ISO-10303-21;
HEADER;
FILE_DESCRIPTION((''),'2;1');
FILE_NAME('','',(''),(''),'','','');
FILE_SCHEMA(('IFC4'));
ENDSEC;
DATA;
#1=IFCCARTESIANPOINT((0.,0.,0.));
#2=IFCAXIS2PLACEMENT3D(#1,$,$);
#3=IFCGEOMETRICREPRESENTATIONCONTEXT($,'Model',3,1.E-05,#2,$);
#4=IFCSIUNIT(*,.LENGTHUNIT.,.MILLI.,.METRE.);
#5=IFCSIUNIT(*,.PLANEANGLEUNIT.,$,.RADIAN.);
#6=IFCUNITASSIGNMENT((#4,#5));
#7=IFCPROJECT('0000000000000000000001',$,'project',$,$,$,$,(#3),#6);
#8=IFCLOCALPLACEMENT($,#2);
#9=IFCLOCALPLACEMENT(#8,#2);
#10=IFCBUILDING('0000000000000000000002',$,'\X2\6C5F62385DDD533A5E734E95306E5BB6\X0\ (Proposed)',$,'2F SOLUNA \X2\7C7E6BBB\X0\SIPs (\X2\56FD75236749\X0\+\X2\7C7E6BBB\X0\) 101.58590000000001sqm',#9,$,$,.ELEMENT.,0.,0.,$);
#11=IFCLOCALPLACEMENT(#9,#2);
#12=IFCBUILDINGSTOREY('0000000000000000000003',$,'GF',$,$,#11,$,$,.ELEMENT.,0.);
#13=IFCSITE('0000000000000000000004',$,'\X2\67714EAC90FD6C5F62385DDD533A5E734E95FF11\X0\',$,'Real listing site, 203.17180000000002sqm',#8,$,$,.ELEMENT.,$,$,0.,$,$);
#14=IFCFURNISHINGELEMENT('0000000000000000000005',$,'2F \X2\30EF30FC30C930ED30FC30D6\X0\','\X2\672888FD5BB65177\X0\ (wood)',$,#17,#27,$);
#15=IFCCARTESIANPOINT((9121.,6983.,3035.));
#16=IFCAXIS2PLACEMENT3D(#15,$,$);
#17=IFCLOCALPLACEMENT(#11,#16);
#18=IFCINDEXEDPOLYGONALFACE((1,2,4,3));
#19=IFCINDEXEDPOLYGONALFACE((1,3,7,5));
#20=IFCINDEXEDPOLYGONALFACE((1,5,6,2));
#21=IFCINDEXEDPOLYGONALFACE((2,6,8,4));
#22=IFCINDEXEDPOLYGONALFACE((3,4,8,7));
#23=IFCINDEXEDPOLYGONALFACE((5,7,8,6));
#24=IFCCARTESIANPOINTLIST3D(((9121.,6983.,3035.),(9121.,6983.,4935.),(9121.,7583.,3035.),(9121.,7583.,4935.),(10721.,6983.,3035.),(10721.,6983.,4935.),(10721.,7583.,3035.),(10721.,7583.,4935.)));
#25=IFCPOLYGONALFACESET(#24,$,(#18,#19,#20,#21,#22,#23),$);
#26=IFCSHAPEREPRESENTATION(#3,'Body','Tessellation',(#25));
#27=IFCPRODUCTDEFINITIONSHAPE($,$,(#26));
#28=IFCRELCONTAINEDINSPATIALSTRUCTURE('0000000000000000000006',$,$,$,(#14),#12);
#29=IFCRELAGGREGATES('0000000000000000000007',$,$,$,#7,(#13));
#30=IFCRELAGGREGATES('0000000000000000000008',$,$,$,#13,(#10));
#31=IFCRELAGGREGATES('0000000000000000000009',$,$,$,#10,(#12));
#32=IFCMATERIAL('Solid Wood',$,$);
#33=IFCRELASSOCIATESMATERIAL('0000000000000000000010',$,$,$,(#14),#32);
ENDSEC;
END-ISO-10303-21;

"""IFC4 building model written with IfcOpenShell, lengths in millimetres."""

from ifc_helpers import new_model, si_unit, frame, frame_2d, origin, place, context, project, spatial, rectangle, extrude, material, element, save


model = new_model("IFC4")

# Units and contexts
model_context = context("Model", 3, precision=1e-05, world=origin())
ifc_project = project(units=[si_unit("LENGTHUNIT", "METRE", prefix="MILLI"), si_unit("PLANEANGLEUNIT", "RADIAN")], contexts=[model_context])

# Site, building, storey
site_placement = place(None, origin())
site = spatial("IfcSite", under=ifc_project, at=site_placement, Name="東京都江戸川区平井１", ObjectType="Real listing site, 203.17180000000002sqm", CompositionType="ELEMENT", RefElevation=0.0)
building_placement = place(site_placement, origin())
building = spatial("IfcBuilding", under=site, at=building_placement, Name="江戸川区平井の家 (Proposed)", ObjectType="2F SOLUNA 籾殻SIPs (国産杉+籾殻) 101.58590000000001sqm", CompositionType="ELEMENT", ElevationOfRefHeight=0.0, ElevationOfTerrain=0.0)
storey_placement = place(building_placement, origin())
storey = spatial("IfcBuildingStorey", under=building, at=storey_placement, Name="GF", CompositionType="ELEMENT", Elevation=0.0)

# Shared definitions
ifc_material_1 = material(Name="Solid Wood")

# Furnishing element
furnishing_1_placement = place(storey_placement, frame((9121.0, 6983.0, 3035.0)))
element("IfcFurnishingElement", 1, at=furnishing_1_placement, inside=storey, material=ifc_material_1, Name="2F ワードローブ", Description="木製家具 (wood)", context=model_context, shape_type="SweptSolid", body=[
    extrude(rectangle(XDim=1600.0, YDim=600.0, at=frame_2d((800.0, 300.0))), frame((9121.0, 6983.0, 3035.0)), (0.0, 0.0, 1.0), 1900.0),
])

save(model, "model.ifc")
